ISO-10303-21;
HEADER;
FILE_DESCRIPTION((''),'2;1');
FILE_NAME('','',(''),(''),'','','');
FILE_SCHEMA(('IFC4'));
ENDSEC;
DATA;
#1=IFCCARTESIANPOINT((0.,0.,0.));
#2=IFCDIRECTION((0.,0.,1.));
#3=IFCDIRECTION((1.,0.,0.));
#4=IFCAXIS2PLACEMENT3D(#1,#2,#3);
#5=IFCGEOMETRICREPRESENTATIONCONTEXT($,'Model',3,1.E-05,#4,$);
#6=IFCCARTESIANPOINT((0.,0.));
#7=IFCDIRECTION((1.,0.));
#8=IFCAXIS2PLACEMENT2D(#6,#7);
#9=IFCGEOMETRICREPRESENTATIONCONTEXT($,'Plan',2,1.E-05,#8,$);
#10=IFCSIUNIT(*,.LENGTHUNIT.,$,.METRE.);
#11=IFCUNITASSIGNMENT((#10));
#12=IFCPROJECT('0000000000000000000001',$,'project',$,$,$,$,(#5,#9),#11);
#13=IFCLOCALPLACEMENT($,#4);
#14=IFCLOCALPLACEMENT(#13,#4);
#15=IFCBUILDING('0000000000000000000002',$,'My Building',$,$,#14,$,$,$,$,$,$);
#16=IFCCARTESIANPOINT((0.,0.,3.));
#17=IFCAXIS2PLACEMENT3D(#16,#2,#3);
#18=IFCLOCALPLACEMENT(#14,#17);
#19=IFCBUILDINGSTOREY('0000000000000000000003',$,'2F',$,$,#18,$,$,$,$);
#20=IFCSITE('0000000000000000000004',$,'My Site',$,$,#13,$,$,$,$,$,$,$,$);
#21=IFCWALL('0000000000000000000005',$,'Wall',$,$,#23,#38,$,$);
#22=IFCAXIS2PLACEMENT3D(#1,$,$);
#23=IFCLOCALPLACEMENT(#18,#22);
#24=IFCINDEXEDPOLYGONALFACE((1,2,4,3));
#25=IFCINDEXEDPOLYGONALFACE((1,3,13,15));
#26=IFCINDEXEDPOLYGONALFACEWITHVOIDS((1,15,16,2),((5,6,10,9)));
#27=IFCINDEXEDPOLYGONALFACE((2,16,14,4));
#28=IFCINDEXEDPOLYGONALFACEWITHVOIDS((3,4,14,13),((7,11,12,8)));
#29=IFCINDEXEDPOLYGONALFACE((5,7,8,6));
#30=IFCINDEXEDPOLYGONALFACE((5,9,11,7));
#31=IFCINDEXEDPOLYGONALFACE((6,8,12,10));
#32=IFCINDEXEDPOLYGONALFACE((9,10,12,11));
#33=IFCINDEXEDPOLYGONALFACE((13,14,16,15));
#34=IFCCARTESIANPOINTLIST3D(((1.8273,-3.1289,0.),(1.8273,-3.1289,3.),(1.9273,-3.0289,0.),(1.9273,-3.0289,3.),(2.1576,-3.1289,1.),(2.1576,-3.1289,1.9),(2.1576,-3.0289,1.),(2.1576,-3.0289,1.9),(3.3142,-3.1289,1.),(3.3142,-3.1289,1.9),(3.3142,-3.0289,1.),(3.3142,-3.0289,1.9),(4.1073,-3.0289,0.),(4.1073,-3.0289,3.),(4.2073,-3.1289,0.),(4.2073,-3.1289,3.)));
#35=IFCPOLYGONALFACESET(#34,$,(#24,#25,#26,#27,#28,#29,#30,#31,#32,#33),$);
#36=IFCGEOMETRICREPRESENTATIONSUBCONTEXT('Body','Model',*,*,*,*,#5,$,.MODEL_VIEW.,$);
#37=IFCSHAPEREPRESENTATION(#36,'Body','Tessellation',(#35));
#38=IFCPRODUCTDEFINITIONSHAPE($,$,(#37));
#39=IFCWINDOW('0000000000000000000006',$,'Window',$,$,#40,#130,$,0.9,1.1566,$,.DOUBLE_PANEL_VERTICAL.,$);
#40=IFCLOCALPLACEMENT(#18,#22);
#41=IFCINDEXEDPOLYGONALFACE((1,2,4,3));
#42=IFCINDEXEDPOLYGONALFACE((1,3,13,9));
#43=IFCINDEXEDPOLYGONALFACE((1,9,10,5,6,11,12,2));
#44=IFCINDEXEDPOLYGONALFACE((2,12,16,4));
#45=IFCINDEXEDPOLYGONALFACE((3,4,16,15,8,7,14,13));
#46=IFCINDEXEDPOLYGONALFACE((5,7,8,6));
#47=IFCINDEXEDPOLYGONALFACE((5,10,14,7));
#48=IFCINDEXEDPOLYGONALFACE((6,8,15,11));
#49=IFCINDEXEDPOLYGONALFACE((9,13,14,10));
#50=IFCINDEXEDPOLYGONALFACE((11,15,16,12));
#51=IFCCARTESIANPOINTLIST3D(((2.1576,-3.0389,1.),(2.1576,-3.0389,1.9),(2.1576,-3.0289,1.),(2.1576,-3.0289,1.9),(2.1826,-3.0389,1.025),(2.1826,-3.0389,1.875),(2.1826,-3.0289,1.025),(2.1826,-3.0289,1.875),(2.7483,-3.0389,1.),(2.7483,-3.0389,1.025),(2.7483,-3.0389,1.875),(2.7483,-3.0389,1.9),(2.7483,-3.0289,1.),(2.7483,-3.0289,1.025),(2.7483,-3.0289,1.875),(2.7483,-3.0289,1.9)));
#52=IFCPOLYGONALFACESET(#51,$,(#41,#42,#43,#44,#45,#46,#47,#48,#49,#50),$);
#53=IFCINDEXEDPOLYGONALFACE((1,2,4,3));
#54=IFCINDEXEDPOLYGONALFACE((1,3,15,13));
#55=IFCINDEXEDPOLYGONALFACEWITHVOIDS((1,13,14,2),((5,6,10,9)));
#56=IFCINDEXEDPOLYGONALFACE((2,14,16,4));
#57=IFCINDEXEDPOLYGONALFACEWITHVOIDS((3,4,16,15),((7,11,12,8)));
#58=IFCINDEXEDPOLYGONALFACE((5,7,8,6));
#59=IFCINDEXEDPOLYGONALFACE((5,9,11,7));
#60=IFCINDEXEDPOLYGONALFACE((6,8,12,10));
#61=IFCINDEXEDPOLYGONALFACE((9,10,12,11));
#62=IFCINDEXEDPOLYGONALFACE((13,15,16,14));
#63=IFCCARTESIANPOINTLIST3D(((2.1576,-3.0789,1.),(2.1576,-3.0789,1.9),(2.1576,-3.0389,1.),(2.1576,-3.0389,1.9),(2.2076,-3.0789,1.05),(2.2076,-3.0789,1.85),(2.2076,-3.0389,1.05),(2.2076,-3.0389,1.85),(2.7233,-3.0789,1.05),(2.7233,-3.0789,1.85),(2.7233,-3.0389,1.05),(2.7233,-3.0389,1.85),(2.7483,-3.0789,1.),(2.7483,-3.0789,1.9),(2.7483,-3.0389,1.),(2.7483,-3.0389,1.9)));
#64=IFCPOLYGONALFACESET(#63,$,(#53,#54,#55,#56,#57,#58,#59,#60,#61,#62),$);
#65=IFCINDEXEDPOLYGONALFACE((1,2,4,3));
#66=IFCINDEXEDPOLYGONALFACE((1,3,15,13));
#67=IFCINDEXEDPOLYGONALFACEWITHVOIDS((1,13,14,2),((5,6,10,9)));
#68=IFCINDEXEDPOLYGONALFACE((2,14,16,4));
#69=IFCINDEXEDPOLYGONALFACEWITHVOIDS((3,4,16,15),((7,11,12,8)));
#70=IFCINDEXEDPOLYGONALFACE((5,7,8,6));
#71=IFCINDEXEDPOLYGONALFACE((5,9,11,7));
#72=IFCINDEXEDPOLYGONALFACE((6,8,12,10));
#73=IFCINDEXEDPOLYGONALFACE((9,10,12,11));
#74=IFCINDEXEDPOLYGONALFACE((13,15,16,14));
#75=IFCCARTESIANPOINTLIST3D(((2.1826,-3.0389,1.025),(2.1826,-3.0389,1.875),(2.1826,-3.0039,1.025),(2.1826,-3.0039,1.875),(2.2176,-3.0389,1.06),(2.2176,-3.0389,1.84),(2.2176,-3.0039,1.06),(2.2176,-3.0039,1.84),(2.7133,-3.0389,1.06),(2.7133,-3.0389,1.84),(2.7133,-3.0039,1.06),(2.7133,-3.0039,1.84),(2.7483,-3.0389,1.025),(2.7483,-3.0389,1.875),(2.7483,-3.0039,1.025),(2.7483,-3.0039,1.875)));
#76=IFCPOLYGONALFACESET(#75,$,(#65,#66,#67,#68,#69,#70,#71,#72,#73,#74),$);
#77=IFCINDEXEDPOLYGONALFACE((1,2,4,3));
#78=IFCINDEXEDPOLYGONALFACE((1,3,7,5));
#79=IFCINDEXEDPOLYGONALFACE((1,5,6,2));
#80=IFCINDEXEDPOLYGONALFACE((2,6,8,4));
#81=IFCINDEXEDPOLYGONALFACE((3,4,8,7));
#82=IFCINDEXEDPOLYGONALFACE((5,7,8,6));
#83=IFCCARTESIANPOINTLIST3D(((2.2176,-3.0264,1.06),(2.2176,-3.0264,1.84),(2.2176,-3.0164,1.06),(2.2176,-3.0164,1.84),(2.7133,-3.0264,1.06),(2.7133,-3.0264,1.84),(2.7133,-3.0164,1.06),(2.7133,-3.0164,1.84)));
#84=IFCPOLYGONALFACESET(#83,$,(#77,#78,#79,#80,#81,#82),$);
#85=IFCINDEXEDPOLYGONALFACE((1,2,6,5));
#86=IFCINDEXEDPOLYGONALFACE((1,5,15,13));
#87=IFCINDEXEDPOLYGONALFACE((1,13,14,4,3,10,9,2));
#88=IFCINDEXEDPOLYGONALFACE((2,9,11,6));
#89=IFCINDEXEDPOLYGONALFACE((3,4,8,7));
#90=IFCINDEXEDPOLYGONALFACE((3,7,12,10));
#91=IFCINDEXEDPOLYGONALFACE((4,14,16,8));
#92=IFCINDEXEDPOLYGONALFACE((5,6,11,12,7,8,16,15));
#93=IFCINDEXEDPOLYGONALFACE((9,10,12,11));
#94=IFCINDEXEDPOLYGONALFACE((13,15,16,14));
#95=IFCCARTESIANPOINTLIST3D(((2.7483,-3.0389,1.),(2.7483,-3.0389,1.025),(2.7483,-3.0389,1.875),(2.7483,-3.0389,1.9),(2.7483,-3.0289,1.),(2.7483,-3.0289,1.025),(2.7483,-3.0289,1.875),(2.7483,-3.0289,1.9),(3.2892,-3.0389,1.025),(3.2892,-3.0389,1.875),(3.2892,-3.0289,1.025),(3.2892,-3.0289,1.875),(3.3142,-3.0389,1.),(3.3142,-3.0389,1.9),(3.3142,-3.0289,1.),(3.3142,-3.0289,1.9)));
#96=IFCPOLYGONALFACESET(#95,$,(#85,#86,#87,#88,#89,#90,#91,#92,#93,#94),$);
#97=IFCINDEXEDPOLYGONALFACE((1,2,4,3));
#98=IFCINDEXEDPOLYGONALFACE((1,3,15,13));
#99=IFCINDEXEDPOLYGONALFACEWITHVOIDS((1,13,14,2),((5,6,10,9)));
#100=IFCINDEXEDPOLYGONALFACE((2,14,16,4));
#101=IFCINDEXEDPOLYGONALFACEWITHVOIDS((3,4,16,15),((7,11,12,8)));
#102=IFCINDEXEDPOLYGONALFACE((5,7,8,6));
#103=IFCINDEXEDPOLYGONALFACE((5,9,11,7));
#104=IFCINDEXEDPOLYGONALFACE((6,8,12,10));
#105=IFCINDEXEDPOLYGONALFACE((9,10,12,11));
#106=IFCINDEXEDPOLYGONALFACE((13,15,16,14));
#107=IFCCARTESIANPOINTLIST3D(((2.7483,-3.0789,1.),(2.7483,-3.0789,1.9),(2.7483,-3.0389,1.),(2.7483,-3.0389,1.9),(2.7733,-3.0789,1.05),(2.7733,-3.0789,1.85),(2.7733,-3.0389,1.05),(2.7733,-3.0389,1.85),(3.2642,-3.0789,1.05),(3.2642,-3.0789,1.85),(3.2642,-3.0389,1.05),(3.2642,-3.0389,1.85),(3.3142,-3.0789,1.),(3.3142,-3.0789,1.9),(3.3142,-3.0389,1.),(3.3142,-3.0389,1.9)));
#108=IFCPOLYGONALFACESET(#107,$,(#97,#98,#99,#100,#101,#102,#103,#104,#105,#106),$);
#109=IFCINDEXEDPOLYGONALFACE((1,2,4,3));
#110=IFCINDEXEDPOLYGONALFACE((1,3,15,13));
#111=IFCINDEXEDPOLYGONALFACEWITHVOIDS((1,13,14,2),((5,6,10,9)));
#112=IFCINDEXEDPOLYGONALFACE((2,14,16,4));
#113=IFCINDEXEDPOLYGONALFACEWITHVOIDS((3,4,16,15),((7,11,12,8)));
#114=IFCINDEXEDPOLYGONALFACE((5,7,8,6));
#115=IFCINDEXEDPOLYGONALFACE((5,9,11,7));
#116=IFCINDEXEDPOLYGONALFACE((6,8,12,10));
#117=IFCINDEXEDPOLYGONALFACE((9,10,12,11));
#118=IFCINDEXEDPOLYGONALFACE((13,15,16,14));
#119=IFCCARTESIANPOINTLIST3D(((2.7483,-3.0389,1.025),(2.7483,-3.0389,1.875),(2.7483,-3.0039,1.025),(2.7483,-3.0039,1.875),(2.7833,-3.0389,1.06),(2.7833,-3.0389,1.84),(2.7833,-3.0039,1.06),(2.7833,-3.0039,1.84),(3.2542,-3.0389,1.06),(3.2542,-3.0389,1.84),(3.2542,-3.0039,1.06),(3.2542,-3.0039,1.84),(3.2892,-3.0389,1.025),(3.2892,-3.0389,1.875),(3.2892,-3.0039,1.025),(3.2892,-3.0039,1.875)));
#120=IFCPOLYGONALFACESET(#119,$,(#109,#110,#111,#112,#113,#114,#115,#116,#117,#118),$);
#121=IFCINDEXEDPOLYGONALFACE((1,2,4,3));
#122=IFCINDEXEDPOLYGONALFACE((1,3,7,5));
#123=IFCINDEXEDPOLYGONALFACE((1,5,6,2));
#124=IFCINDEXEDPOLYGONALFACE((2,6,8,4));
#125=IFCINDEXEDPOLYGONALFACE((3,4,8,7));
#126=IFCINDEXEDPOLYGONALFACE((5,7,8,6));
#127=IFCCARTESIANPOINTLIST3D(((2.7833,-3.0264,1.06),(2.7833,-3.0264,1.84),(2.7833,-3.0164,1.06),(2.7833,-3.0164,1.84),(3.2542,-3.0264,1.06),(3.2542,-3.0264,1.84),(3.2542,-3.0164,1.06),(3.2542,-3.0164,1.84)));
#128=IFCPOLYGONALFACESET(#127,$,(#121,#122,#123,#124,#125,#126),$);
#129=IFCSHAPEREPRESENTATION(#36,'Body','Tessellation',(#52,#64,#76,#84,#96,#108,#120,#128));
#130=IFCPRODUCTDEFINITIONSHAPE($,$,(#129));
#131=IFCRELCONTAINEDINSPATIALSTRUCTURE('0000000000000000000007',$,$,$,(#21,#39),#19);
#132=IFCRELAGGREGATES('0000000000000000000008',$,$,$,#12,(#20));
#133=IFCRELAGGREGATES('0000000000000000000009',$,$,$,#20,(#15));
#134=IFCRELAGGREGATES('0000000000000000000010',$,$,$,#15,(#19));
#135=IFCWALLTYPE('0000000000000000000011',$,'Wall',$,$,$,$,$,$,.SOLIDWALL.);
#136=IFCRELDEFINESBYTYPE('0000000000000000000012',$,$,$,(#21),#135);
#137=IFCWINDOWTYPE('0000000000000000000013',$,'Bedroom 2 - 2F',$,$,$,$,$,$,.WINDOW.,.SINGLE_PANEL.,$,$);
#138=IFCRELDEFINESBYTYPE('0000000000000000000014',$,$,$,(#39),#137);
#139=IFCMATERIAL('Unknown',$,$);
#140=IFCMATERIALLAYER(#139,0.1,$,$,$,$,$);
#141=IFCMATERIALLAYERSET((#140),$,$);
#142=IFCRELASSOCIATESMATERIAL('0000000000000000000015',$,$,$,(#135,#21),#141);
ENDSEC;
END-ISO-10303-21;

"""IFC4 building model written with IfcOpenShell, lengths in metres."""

from ifc_helpers import new_model, entity, si_unit, frame, origin_with_axes, origin_2d_with_axis, place, context, subcontext, project, spatial, line, indexed_curve, outline, extrude, shape, source, transform, mapped, material, layer, layer_set, layer_usage, type_object, type_shapes, element, fill, save


model = new_model("IFC4")

# Units and contexts
model_context = context("Model", 3, precision=1e-05, world=origin_with_axes())
plan_context = context("Plan", 2, precision=1e-05, world=origin_2d_with_axis())
body_context_1 = subcontext(model_context, "Body", "Model", "MODEL_VIEW")
body_context_2 = subcontext(plan_context, "Body", "Plan", "PLAN_VIEW")
ifc_project = project(units=[si_unit("LENGTHUNIT", "METRE")], contexts=[model_context, plan_context])

# Site, building, storey
site_placement = place(None, origin_with_axes())
site = spatial("IfcSite", under=ifc_project, at=site_placement, Name="My Site")
building_placement = place(site_placement, origin_with_axes())
building = spatial("IfcBuilding", under=site, at=building_placement, Name="My Building")
storey_placement = place(building_placement, frame((0.0, 0.0, 3.0), z_axis=(0.0, 0.0, 1.0), x_axis=(1.0, 0.0, 0.0)))
storey = spatial("IfcBuildingStorey", under=building, at=storey_placement, Name="2F")

# Shared definitions
ifc_material = material(Name="Unknown")

# Shared definitions
ifc_layer = layer(ifc_material, 0.1)
ifc_layer_set = layer_set([ifc_layer])
wall_type = type_object("IfcWallType", Name="Wall", PredefinedType="SOLIDWALL", material=ifc_layer_set)

# Wall, opening, window
ifc_layer_usage_1 = layer_usage(ifc_layer_set, "AXIS2", "POSITIVE", 0.0)
wall_1_placement = place(storey_placement, frame((1.8273, -3.1289, 0.0), z_axis=(0.0, 0.0, 1.0), x_axis=(1.0, 0.0, 0.0)))
wall_1 = element("IfcWall", 1, at=wall_1_placement, inside=storey, type_object=wall_type, material=ifc_layer_usage_1, Name="Wall", context=body_context_1, shape_type="SweptSolid", body=[
    extrude(outline(indexed_curve([(0.0, 0.0), (0.1, 0.1), (2.28, 0.1), (2.38, 0.0)], segments=[line(1, 2, 3, 4, 1)])), origin_with_axes(), (0.0, 0.0, 1.0), 3.0),
])
shared_shape_1 = source(origin_with_axes(), body_context_1, "Body", "SweptSolid", [
    extrude(outline(indexed_curve([(0.0, 0.0), (1.1566, 0.0), (1.1566, 0.9), (0.0, 0.9)], segments=[line(1, 2, 3, 4, 1)])), frame((0.0, -0.6, 0.0), z_axis=(0.0, -1.0, 0.0), x_axis=(1.0, 0.0, 0.0)), (0.0, 0.0, -1.0), 1.2),
])
opening_1_placement = place(wall_1_placement, frame((0.3303, 0.0, 1.0), z_axis=(0.0, 0.0, 1.0), x_axis=(1.0, 0.0, 0.0)))
opening_1 = element("IfcOpeningElement", 2, at=opening_1_placement, cuts=wall_1, PredefinedType="OPENING", context=body_context_1, shape_type="MappedRepresentation", body=[
    mapped(shared_shape_1, transform((0.0, 0.0, 0.0), x_axis=(1.0, 0.0, 0.0), y_axis=(0.0, 1.0, 0.0), z_axis=(0.0, 0.0, 1.0), scale=1.0)),
])
window_type = type_object("IfcWindowType", Name="Bedroom 2 - 2F", PartitioningType="SINGLE_PANEL", PredefinedType="WINDOW")
shared_shape_2 = source(origin_with_axes(), body_context_1, "Body", "SweptSolid", [
    extrude(outline(indexed_curve([(0.5908, 0.0), (0.0, 0.0), (0.0, 0.9), (0.5908, 0.9), (0.5908, 0.875), (0.025, 0.875), (0.025, 0.025), (0.5908, 0.025)], segments=[line(1, 2, 3, 4, 5, 6, 7, 8, 1)])), frame((0.0, 0.09, 0.0), z_axis=(0.0, -1.0, 0.0), x_axis=(1.0, 0.0, 0.0)), (0.0, 0.0, -1.0), 0.01),
    extrude(outline(indexed_curve([(0.0, 0.0), (0.5908, 0.0), (0.5908, 0.9), (0.0, 0.9)], segments=[line(1, 2, 3, 4, 1)]), holes=[indexed_curve([(0.05, 0.05), (0.5658, 0.05), (0.5658, 0.85), (0.05, 0.85)], segments=[line(1, 2, 3, 4, 1)])]), frame((0.0, 0.05, 0.0), z_axis=(0.0, -1.0, 0.0), x_axis=(1.0, 0.0, 0.0)), (0.0, 0.0, -1.0), 0.04),
    extrude(outline(indexed_curve([(0.0, 0.0), (0.5658, 0.0), (0.5658, 0.85), (0.0, 0.85)], segments=[line(1, 2, 3, 4, 1)]), holes=[indexed_curve([(0.035, 0.035), (0.5308, 0.035), (0.5308, 0.815), (0.035, 0.815)], segments=[line(1, 2, 3, 4, 1)])]), frame((0.025, 0.09, 0.025), z_axis=(0.0, -1.0, 0.0), x_axis=(1.0, 0.0, 0.0)), (0.0, 0.0, -1.0), 0.035),
    extrude(outline(indexed_curve([(0.035, 0.035), (0.5308, 0.035), (0.5308, 0.815), (0.035, 0.815)], segments=[line(1, 2, 3, 4, 1)])), frame((0.025, 0.1025, 0.025), z_axis=(0.0, -1.0, 0.0), x_axis=(1.0, 0.0, 0.0)), (0.0, 0.0, -1.0), 0.01),
    extrude(outline(indexed_curve([(0.0, 0.9), (0.5659, 0.9), (0.5659, 0.0), (0.0, 0.0), (0.0, 0.025), (0.5409, 0.025), (0.5409, 0.875), (0.0, 0.875)], segments=[line(1, 2, 3, 4, 5, 6, 7, 8, 1)])), frame((0.5908, 0.09, 0.0), z_axis=(0.0, -1.0, 0.0), x_axis=(1.0, 0.0, 0.0)), (0.0, 0.0, -1.0), 0.01),
    extrude(outline(indexed_curve([(0.0, 0.0), (0.5659, 0.0), (0.5659, 0.9), (0.0, 0.9)], segments=[line(1, 2, 3, 4, 1)]), holes=[indexed_curve([(0.025, 0.05), (0.5159, 0.05), (0.5159, 0.85), (0.025, 0.85)], segments=[line(1, 2, 3, 4, 1)])]), frame((0.5908, 0.05, 0.0), z_axis=(0.0, -1.0, 0.0), x_axis=(1.0, 0.0, 0.0)), (0.0, 0.0, -1.0), 0.04),
    extrude(outline(indexed_curve([(0.0, 0.0), (0.5409, 0.0), (0.5409, 0.85), (0.0, 0.85)], segments=[line(1, 2, 3, 4, 1)]), holes=[indexed_curve([(0.035, 0.035), (0.5059, 0.035), (0.5059, 0.815), (0.035, 0.815)], segments=[line(1, 2, 3, 4, 1)])]), frame((0.5908, 0.09, 0.025), z_axis=(0.0, -1.0, 0.0), x_axis=(1.0, 0.0, 0.0)), (0.0, 0.0, -1.0), 0.035),
    extrude(outline(indexed_curve([(0.035, 0.035), (0.5059, 0.035), (0.5059, 0.815), (0.035, 0.815)], segments=[line(1, 2, 3, 4, 1)])), frame((0.5908, 0.1025, 0.025), z_axis=(0.0, -1.0, 0.0), x_axis=(1.0, 0.0, 0.0)), (0.0, 0.0, -1.0), 0.01),
])
shared_shape_3 = source(origin_with_axes(), body_context_2, "Body", "Curve2D", [
    entity("IfcIndexedPolyCurve", entity("IfcCartesianPointList2D", [[0.05, 0.05], [0.5658, 0.05]])),
    entity("IfcIndexedPolyCurve", entity("IfcCartesianPointList2D", [[0.0, 0.1], [0.025, 0.1], [0.025, 0.09], [0.05, 0.09], [0.05, 0.05], [0.0, 0.05]]), [entity("IfcLineIndex", [1, 2, 3, 4, 5, 6, 1])]),
    entity("IfcIndexedPolyCurve", entity("IfcCartesianPointList2D", [[0.5908, 0.1], [0.5908, 0.1], [0.5908, 0.09], [0.5658, 0.09], [0.5658, 0.05], [0.5908, 0.05]])),
    entity("IfcIndexedPolyCurve", entity("IfcCartesianPointList2D", [[0.025, 0.09], [0.06, 0.09], [0.06, 0.125], [0.025, 0.125]]), [entity("IfcLineIndex", [1, 2, 3, 4, 1])]),
    entity("IfcIndexedPolyCurve", entity("IfcCartesianPointList2D", [[0.5908, 0.09], [0.5558, 0.09], [0.5558, 0.125], [0.5908, 0.125]]), [entity("IfcLineIndex", [1, 2, 3, 4, 1])]),
    entity("IfcIndexedPolyCurve", entity("IfcCartesianPointList2D", [[0.06, 0.09], [0.5558, 0.09]])),
    entity("IfcIndexedPolyCurve", entity("IfcCartesianPointList2D", [[0.06, 0.125], [0.5558, 0.125]])),
    entity("IfcIndexedPolyCurve", entity("IfcCartesianPointList2D", [[0.06, 0.1075], [0.5558, 0.1075]])),
    entity("IfcIndexedPolyCurve", entity("IfcCartesianPointList2D", [[0.6158, 0.05], [1.1066, 0.05]])),
    entity("IfcIndexedPolyCurve", entity("IfcCartesianPointList2D", [[0.5908, 0.1], [0.5908, 0.1], [0.5908, 0.09], [0.6158, 0.09], [0.6158, 0.05], [0.5908, 0.05]])),
    entity("IfcIndexedPolyCurve", entity("IfcCartesianPointList2D", [[1.1566, 0.1], [1.1316, 0.1], [1.1316, 0.09], [1.1066, 0.09], [1.1066, 0.05], [1.1566, 0.05]]), [entity("IfcLineIndex", [1, 2, 3, 4, 5, 6, 1])]),
    entity("IfcIndexedPolyCurve", entity("IfcCartesianPointList2D", [[0.5908, 0.09], [0.6258, 0.09], [0.6258, 0.125], [0.5908, 0.125]]), [entity("IfcLineIndex", [1, 2, 3, 4, 1])]),
    entity("IfcIndexedPolyCurve", entity("IfcCartesianPointList2D", [[1.1316, 0.09], [1.0966, 0.09], [1.0966, 0.125], [1.1316, 0.125]]), [entity("IfcLineIndex", [1, 2, 3, 4, 1])]),
    entity("IfcIndexedPolyCurve", entity("IfcCartesianPointList2D", [[0.6258, 0.09], [1.0966, 0.09]])),
    entity("IfcIndexedPolyCurve", entity("IfcCartesianPointList2D", [[0.6258, 0.125], [1.0966, 0.125]])),
    entity("IfcIndexedPolyCurve", entity("IfcCartesianPointList2D", [[0.6258, 0.1075], [1.0966, 0.1075]])),
])
type_shapes(window_type, [shared_shape_2, shared_shape_3])
window_placement = place(opening_1_placement, origin_with_axes())
window = element("IfcWindow", 3, at=window_placement, inside=storey, type_object=window_type, Name="Window", OverallHeight=0.9, OverallWidth=1.1566, PartitioningType="DOUBLE_PANEL_VERTICAL", shapes=[
    shape(body_context_1, "Body", "MappedRepresentation", [mapped(shared_shape_2, transform((0.0, 0.0, 0.0), x_axis=(1.0, 0.0, 0.0), y_axis=(0.0, 1.0, 0.0), z_axis=(0.0, 0.0, 1.0), scale=1.0))]),
    shape(body_context_2, "Body", "MappedRepresentation", [mapped(shared_shape_3, transform((0.0, 0.0, 0.0), x_axis=(1.0, 0.0, 0.0), y_axis=(0.0, 1.0, 0.0), z_axis=(0.0, 0.0, 1.0), scale=1.0))]),
])
fill(opening_1, window)

save(model, "model.ifc")
